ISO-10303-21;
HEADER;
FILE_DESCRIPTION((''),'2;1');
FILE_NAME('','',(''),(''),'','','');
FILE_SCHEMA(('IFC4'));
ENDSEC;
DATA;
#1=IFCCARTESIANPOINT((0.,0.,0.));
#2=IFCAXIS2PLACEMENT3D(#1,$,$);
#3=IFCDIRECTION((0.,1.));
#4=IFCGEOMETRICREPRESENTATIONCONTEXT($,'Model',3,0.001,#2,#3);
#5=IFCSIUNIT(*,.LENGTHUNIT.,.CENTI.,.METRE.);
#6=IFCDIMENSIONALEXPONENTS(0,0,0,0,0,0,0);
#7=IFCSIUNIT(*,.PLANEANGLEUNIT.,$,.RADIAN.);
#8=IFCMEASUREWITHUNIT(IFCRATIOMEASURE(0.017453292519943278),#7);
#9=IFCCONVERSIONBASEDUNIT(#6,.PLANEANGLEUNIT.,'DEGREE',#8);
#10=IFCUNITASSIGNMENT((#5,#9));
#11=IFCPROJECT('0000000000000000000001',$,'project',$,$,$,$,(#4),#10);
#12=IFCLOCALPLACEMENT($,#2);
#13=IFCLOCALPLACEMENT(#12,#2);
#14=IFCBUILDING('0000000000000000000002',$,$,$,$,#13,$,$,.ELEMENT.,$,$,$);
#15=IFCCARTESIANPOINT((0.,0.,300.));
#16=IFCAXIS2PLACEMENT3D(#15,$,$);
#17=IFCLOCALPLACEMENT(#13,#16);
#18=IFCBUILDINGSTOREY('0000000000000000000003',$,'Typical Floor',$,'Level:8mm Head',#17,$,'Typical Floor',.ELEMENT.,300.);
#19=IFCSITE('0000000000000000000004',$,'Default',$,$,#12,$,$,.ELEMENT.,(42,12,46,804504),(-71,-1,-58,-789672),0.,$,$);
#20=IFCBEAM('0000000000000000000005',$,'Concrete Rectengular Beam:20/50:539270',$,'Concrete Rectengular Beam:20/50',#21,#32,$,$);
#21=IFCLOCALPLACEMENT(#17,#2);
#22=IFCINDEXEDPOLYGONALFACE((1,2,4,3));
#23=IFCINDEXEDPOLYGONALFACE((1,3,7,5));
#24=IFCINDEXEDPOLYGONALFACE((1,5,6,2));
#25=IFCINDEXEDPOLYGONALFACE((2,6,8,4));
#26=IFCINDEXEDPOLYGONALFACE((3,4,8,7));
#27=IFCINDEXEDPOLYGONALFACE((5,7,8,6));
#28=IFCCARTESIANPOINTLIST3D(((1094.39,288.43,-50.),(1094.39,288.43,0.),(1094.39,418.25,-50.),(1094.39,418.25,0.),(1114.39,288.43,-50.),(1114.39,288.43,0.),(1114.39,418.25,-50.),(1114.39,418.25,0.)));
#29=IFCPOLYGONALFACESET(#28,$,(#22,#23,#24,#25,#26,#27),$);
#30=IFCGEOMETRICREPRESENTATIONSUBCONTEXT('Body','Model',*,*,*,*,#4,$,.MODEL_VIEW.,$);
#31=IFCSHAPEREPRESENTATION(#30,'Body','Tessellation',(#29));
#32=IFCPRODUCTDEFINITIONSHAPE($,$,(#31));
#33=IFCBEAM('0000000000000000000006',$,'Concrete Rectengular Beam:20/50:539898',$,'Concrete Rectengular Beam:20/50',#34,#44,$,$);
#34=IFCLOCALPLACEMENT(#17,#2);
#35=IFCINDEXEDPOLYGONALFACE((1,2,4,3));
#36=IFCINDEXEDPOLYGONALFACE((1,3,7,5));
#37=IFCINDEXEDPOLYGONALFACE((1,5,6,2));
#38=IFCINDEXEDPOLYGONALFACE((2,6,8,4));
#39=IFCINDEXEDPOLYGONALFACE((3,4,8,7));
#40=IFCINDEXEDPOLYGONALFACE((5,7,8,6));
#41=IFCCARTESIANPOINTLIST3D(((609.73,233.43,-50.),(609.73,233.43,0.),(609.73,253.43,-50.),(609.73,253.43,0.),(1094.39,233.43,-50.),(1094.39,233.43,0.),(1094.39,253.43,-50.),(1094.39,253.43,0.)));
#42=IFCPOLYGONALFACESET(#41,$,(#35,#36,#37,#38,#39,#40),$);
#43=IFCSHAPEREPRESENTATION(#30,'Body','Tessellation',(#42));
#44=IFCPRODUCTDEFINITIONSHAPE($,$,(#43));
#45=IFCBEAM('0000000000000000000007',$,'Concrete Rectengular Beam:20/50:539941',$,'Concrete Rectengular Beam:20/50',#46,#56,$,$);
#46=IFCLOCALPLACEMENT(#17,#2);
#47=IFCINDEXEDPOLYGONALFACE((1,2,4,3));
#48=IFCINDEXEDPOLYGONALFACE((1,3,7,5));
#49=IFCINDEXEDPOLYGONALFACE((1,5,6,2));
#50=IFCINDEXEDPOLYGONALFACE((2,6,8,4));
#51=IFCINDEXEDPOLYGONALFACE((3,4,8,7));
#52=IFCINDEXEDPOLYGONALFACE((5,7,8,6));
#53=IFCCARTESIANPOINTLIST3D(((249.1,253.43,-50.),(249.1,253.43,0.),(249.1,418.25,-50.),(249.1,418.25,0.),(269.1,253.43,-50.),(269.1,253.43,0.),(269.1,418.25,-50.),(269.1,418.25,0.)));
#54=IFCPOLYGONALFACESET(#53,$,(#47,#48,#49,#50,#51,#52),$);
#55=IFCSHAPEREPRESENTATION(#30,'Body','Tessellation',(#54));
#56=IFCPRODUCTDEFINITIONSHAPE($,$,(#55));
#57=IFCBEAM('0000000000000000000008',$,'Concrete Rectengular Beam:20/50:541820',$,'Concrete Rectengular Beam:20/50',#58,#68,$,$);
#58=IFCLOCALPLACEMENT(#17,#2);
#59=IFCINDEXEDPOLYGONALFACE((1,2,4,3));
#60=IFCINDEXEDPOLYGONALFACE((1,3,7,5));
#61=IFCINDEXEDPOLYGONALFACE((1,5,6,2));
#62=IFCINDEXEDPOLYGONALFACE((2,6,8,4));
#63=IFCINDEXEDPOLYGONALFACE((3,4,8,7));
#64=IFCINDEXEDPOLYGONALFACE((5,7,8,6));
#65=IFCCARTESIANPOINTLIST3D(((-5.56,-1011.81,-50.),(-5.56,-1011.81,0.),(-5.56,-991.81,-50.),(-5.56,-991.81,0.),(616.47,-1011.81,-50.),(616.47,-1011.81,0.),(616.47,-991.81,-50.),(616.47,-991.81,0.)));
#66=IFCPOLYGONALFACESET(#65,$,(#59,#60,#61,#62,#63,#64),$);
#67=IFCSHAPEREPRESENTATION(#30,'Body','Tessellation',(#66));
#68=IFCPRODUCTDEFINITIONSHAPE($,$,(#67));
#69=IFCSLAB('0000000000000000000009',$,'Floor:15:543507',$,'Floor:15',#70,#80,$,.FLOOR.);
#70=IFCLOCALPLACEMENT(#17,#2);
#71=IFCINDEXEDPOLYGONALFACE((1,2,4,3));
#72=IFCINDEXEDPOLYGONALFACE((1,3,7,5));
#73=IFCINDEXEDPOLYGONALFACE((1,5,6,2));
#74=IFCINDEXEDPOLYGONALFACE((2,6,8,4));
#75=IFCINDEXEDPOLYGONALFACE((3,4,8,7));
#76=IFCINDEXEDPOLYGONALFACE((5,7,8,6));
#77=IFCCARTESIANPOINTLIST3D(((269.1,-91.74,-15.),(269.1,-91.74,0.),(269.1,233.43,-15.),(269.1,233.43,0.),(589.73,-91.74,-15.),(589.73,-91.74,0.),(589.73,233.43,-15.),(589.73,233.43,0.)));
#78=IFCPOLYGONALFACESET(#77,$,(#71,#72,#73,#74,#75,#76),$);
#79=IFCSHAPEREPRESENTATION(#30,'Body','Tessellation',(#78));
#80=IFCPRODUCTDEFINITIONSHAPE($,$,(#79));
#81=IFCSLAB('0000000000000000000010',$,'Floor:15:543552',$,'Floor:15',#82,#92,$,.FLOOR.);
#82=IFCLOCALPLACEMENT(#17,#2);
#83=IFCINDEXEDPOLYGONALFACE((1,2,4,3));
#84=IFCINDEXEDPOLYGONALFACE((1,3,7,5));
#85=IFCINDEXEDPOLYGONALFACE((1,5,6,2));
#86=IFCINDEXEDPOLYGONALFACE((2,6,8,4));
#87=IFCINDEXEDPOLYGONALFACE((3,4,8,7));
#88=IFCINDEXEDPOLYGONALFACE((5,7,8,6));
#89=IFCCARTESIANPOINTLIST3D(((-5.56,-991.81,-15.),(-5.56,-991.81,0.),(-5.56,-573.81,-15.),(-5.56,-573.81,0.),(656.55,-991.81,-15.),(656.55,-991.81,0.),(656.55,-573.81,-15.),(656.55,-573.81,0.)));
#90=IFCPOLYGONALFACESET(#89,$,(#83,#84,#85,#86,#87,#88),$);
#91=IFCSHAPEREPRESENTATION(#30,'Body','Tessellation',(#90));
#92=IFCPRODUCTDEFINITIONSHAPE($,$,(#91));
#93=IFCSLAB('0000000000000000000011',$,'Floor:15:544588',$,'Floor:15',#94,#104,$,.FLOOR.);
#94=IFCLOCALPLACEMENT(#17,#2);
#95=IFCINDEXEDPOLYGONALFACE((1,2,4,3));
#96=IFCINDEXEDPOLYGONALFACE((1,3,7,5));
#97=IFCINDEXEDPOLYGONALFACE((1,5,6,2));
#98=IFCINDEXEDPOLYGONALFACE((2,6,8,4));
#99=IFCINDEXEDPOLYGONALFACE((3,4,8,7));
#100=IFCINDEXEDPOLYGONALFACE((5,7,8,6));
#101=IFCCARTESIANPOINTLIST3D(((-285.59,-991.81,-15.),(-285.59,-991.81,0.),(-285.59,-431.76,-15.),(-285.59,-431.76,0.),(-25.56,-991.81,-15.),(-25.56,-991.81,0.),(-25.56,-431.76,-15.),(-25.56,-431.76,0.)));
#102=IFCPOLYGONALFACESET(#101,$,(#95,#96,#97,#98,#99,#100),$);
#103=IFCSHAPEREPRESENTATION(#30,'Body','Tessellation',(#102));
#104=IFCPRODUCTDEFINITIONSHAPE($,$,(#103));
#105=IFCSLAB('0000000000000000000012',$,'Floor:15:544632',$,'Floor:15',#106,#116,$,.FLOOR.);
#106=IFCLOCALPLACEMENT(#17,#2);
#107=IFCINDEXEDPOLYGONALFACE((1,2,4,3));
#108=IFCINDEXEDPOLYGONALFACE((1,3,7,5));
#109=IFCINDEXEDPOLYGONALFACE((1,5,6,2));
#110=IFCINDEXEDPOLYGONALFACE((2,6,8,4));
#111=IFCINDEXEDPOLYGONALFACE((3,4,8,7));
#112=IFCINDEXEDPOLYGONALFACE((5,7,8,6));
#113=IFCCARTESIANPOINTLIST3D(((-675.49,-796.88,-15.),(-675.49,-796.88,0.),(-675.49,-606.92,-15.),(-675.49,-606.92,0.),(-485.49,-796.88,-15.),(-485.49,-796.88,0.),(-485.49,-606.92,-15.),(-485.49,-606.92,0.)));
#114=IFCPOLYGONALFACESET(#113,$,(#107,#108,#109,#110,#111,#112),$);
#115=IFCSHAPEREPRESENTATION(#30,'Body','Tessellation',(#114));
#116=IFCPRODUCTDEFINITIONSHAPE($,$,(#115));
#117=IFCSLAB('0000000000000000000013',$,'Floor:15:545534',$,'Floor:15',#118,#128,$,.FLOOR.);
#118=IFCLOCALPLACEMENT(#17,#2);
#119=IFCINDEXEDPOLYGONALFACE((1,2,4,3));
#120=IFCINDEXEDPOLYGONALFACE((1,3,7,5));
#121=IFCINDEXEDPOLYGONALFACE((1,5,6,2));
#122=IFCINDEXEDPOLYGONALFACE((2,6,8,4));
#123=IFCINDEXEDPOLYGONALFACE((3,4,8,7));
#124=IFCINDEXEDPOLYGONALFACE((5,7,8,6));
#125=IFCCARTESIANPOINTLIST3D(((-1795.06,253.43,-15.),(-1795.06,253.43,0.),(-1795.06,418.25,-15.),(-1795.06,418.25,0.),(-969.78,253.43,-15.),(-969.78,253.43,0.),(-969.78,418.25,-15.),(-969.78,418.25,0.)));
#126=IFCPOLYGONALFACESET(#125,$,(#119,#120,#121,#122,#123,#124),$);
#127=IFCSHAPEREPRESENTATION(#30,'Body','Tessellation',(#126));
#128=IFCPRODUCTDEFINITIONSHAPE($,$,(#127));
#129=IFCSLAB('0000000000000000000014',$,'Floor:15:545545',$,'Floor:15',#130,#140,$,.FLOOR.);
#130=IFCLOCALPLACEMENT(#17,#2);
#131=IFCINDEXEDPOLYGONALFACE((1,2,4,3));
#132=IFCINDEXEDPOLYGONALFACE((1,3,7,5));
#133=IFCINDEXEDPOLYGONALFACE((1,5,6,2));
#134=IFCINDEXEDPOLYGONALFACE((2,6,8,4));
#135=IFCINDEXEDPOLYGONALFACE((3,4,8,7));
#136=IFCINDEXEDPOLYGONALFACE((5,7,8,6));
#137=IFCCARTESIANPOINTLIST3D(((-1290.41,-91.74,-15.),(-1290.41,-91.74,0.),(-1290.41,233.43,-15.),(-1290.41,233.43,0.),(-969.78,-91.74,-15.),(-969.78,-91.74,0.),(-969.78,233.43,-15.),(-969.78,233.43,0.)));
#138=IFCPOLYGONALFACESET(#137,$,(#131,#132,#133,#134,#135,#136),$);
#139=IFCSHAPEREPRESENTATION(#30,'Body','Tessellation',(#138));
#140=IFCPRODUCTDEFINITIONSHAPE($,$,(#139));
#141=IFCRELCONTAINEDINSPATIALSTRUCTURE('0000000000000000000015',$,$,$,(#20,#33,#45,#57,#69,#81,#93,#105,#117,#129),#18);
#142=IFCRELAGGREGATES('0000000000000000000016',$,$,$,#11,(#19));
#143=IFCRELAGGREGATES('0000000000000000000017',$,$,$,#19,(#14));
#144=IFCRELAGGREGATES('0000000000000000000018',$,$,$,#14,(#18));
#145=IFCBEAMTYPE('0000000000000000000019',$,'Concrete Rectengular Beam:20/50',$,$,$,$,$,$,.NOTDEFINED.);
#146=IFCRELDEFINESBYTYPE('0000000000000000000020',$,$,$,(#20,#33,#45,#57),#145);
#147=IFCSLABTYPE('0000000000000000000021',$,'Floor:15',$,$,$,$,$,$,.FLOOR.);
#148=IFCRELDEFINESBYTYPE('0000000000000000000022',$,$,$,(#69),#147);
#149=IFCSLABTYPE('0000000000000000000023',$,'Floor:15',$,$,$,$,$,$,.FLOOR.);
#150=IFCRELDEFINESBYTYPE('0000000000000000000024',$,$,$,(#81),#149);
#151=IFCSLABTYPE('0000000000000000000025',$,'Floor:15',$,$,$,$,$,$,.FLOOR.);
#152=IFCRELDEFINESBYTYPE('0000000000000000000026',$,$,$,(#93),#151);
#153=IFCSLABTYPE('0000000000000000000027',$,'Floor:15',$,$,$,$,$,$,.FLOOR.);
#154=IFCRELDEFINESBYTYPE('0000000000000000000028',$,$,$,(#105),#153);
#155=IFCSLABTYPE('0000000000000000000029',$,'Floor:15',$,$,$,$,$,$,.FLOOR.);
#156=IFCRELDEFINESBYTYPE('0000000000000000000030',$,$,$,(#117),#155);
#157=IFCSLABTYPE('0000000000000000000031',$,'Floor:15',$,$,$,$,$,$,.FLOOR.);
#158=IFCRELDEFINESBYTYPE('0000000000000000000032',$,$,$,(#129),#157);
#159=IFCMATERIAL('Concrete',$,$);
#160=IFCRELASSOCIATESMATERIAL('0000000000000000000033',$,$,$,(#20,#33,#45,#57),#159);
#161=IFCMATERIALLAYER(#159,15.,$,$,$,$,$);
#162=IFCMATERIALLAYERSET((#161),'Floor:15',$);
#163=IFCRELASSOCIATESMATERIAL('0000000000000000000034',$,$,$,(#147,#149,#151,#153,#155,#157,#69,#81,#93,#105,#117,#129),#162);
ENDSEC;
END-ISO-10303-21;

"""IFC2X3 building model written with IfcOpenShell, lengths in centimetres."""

from ifc_helpers import new_model, entity, si_unit, converted_unit, direction, frame, frame_2d, origin, origin_2d_with_axis, place, context, subcontext, project, spatial, rectangle, extrude, material, layer, layer_set, layer_usage, type_object, element, save


model = new_model("IFC2X3")

# Units and contexts
model_context = context("Model", 3, precision=0.001, world=origin(), true_north=direction((0.0, 1.0)))
body_context = subcontext(model_context, "Body", "Model", "MODEL_VIEW")
ifc_project = project(units=[si_unit("LENGTHUNIT", "METRE", prefix="CENTI"), converted_unit("PLANEANGLEUNIT", "DEGREE", entity("IfcRatioMeasure", 0.017453292519943278), si_unit("PLANEANGLEUNIT", "RADIAN"), dimensions=[0, 0, 0, 0, 0, 0, 0])], contexts=[model_context])

# Site, building, storey
site_placement = place(None, origin())
site = spatial("IfcSite", under=ifc_project, at=site_placement, Name="Default", CompositionType="ELEMENT", RefLatitude=(42, 12, 46, 804504), RefLongitude=(-71, -1, -58, -789672), RefElevation=0.0)
building_placement = place(site_placement, origin())
building = spatial("IfcBuilding", under=site, at=building_placement, CompositionType="ELEMENT")
storey_placement = place(building_placement, frame((0.0, 0.0, 300.0)))
storey = spatial("IfcBuildingStorey", under=building, at=storey_placement, Name="Typical Floor", ObjectType="Level:8mm Head", LongName="Typical Floor", CompositionType="ELEMENT", Elevation=300.0)

# Beams
ifc_material = material(Name="Concrete")
beam_type = type_object("IfcBeamType", Name="Concrete Rectengular Beam:20/50", PredefinedType="NOTDEFINED")
beam_1_placement = place(storey_placement, frame((1104.39, 428.25, 0.0), z_axis=(0.0, 0.0, 1.0), x_axis=(0.0, -1.0, 0.0)))
element("IfcBeam", 1, at=beam_1_placement, inside=storey, type_object=beam_type, material=ifc_material, Name="Concrete Rectengular Beam:20/50:539270", ObjectType="Concrete Rectengular Beam:20/50", context=body_context, shape_type="SweptSolid", body=[
    extrude(rectangle(XDim=50.0, YDim=20.0, at=frame_2d((0.0, 0.0), x_axis=(1.0, 0.0))), frame((10.0, 0.0, -25.0), z_axis=(1.0, 0.0, 0.0), x_axis=(0.0, 0.0, -1.0)), (0.0, 0.0, 1.0), 129.82),
])
beam_2_placement = place(storey_placement, frame((1104.39, 243.43, 0.0), z_axis=(0.0, 0.0, 1.0), x_axis=(-1.0, 0.0, 0.0)))
element("IfcBeam", 2, at=beam_2_placement, inside=storey, type_object=beam_type, material=ifc_material, Name="Concrete Rectengular Beam:20/50:539898", ObjectType="Concrete Rectengular Beam:20/50", context=body_context, shape_type="SweptSolid", body=[
    extrude(rectangle(XDim=50.0, YDim=20.0, at=frame_2d((0.0, 0.0), x_axis=(1.0, 0.0))), frame((10.0, 0.0, -25.0), z_axis=(1.0, 0.0, 0.0), x_axis=(0.0, 0.0, -1.0)), (0.0, 0.0, 1.0), 484.65),
])
beam_3_placement = place(storey_placement, frame((259.1, 428.25, 0.0), z_axis=(0.0, 0.0, 1.0), x_axis=(0.0, -1.0, 0.0)))
element("IfcBeam", 3, at=beam_3_placement, inside=storey, type_object=beam_type, material=ifc_material, Name="Concrete Rectengular Beam:20/50:539941", ObjectType="Concrete Rectengular Beam:20/50", context=body_context, shape_type="SweptSolid", body=[
    extrude(rectangle(XDim=50.0, YDim=20.0, at=frame_2d((0.0, 0.0), x_axis=(1.0, 0.0))), frame((10.0, 0.0, -25.0), z_axis=(1.0, 0.0, 0.0), x_axis=(0.0, 0.0, -1.0)), (0.0, 0.0, 1.0), 164.82),
])
beam_4_placement = place(storey_placement, frame((666.47, -1001.81, 0.0), z_axis=(0.0, 0.0, 1.0), x_axis=(-1.0, 0.0, 0.0)))
element("IfcBeam", 4, at=beam_4_placement, inside=storey, type_object=beam_type, material=ifc_material, Name="Concrete Rectengular Beam:20/50:541820", ObjectType="Concrete Rectengular Beam:20/50", context=body_context, shape_type="SweptSolid", body=[
    extrude(rectangle(XDim=50.0, YDim=20.0, at=frame_2d((0.0, 0.0), x_axis=(1.0, 0.0))), frame((50.0, 0.0, -25.0), z_axis=(1.0, 0.0, 0.0), x_axis=(0.0, 0.0, -1.0)), (0.0, 0.0, 1.0), 622.03),
])

# Slabs
ifc_layer = layer(ifc_material, 15.0)
ifc_layer_set = layer_set([ifc_layer], Name="Floor:15")
ifc_layer_usage_1 = layer_usage(ifc_layer_set, "AXIS3", "POSITIVE", 0.0)
slab_type_1 = type_object("IfcSlabType", Name="Floor:15", PredefinedType="FLOOR", material=ifc_layer_set)
slab_1_placement = place(storey_placement, origin())
element("IfcSlab", 5, at=slab_1_placement, inside=storey, type_object=slab_type_1, material=ifc_layer_usage_1, Name="Floor:15:543507", ObjectType="Floor:15", PredefinedType="FLOOR", context=body_context, shape_type="SweptSolid", body=[
    extrude(rectangle(XDim=325.17, YDim=320.63, at=origin_2d_with_axis()), frame((429.42, 70.84, 0.0), z_axis=(0.0, 0.0, -1.0), x_axis=(0.0, 1.0, 0.0)), (0.0, 0.0, 1.0), 15.0),
])
ifc_layer_usage_2 = layer_usage(ifc_layer_set, "AXIS3", "POSITIVE", 0.0)
slab_type_2 = type_object("IfcSlabType", Name="Floor:15", PredefinedType="FLOOR", material=ifc_layer_set)
slab_2_placement = place(storey_placement, origin())
element("IfcSlab", 6, at=slab_2_placement, inside=storey, type_object=slab_type_2, material=ifc_layer_usage_2, Name="Floor:15:543552", ObjectType="Floor:15", PredefinedType="FLOOR", context=body_context, shape_type="SweptSolid", body=[
    extrude(rectangle(XDim=418.0, YDim=662.11, at=frame_2d((0.0, 0.0), x_axis=(1.0, 0.0))), frame((325.49, -782.81, 0.0), z_axis=(0.0, 0.0, -1.0), x_axis=(0.0, 1.0, 0.0)), (0.0, 0.0, 1.0), 15.0),
])
ifc_layer_usage_3 = layer_usage(ifc_layer_set, "AXIS3", "POSITIVE", 0.0)
slab_type_3 = type_object("IfcSlabType", Name="Floor:15", PredefinedType="FLOOR", material=ifc_layer_set)
slab_3_placement = place(storey_placement, origin())
element("IfcSlab", 7, at=slab_3_placement, inside=storey, type_object=slab_type_3, material=ifc_layer_usage_3, Name="Floor:15:544588", ObjectType="Floor:15", PredefinedType="FLOOR", context=body_context, shape_type="SweptSolid", body=[
    extrude(rectangle(XDim=560.05, YDim=260.02, at=frame_2d((0.0, 0.0), x_axis=(1.0, 0.0))), frame((-155.57, -711.79, 0.0), z_axis=(0.0, 0.0, -1.0), x_axis=(0.0, 1.0, 0.0)), (0.0, 0.0, 1.0), 15.0),
])
ifc_layer_usage_4 = layer_usage(ifc_layer_set, "AXIS3", "POSITIVE", 0.0)
slab_type_4 = type_object("IfcSlabType", Name="Floor:15", PredefinedType="FLOOR", material=ifc_layer_set)
slab_4_placement = place(storey_placement, origin())
element("IfcSlab", 8, at=slab_4_placement, inside=storey, type_object=slab_type_4, material=ifc_layer_usage_4, Name="Floor:15:544632", ObjectType="Floor:15", PredefinedType="FLOOR", context=body_context, shape_type="SweptSolid", body=[
    extrude(rectangle(XDim=189.96, YDim=190.0, at=frame_2d((0.0, 0.0), x_axis=(1.0, 0.0))), frame((-580.49, -701.9, 0.0), z_axis=(0.0, 0.0, -1.0), x_axis=(0.0, 1.0, 0.0)), (0.0, 0.0, 1.0), 15.0),
])
ifc_layer_usage_5 = layer_usage(ifc_layer_set, "AXIS3", "POSITIVE", 0.0)
slab_type_5 = type_object("IfcSlabType", Name="Floor:15", PredefinedType="FLOOR", material=ifc_layer_set)
slab_5_placement = place(storey_placement, origin())
element("IfcSlab", 9, at=slab_5_placement, inside=storey, type_object=slab_type_5, material=ifc_layer_usage_5, Name="Floor:15:545534", ObjectType="Floor:15", PredefinedType="FLOOR", context=body_context, shape_type="SweptSolid", body=[
    extrude(rectangle(XDim=164.82, YDim=825.28, at=frame_2d((0.0, 0.0), x_axis=(1.0, 0.0))), frame((-1382.42, 335.84, 0.0), z_axis=(0.0, 0.0, -1.0), x_axis=(0.0, 1.0, 0.0)), (0.0, 0.0, 1.0), 15.0),
])
ifc_layer_usage_6 = layer_usage(ifc_layer_set, "AXIS3", "POSITIVE", 0.0)
slab_type_6 = type_object("IfcSlabType", Name="Floor:15", PredefinedType="FLOOR", material=ifc_layer_set)
slab_6_placement = place(storey_placement, origin())
element("IfcSlab", 10, at=slab_6_placement, inside=storey, type_object=slab_type_6, material=ifc_layer_usage_6, Name="Floor:15:545545", ObjectType="Floor:15", PredefinedType="FLOOR", context=body_context, shape_type="SweptSolid", body=[
    extrude(rectangle(XDim=325.17, YDim=320.63, at=frame_2d((0.0, 0.0), x_axis=(1.0, 0.0))), frame((-1130.09, 70.84, 0.0), z_axis=(0.0, 0.0, -1.0), x_axis=(0.0, 1.0, 0.0)), (0.0, 0.0, 1.0), 15.0),
])

save(model, "model.ifc")
